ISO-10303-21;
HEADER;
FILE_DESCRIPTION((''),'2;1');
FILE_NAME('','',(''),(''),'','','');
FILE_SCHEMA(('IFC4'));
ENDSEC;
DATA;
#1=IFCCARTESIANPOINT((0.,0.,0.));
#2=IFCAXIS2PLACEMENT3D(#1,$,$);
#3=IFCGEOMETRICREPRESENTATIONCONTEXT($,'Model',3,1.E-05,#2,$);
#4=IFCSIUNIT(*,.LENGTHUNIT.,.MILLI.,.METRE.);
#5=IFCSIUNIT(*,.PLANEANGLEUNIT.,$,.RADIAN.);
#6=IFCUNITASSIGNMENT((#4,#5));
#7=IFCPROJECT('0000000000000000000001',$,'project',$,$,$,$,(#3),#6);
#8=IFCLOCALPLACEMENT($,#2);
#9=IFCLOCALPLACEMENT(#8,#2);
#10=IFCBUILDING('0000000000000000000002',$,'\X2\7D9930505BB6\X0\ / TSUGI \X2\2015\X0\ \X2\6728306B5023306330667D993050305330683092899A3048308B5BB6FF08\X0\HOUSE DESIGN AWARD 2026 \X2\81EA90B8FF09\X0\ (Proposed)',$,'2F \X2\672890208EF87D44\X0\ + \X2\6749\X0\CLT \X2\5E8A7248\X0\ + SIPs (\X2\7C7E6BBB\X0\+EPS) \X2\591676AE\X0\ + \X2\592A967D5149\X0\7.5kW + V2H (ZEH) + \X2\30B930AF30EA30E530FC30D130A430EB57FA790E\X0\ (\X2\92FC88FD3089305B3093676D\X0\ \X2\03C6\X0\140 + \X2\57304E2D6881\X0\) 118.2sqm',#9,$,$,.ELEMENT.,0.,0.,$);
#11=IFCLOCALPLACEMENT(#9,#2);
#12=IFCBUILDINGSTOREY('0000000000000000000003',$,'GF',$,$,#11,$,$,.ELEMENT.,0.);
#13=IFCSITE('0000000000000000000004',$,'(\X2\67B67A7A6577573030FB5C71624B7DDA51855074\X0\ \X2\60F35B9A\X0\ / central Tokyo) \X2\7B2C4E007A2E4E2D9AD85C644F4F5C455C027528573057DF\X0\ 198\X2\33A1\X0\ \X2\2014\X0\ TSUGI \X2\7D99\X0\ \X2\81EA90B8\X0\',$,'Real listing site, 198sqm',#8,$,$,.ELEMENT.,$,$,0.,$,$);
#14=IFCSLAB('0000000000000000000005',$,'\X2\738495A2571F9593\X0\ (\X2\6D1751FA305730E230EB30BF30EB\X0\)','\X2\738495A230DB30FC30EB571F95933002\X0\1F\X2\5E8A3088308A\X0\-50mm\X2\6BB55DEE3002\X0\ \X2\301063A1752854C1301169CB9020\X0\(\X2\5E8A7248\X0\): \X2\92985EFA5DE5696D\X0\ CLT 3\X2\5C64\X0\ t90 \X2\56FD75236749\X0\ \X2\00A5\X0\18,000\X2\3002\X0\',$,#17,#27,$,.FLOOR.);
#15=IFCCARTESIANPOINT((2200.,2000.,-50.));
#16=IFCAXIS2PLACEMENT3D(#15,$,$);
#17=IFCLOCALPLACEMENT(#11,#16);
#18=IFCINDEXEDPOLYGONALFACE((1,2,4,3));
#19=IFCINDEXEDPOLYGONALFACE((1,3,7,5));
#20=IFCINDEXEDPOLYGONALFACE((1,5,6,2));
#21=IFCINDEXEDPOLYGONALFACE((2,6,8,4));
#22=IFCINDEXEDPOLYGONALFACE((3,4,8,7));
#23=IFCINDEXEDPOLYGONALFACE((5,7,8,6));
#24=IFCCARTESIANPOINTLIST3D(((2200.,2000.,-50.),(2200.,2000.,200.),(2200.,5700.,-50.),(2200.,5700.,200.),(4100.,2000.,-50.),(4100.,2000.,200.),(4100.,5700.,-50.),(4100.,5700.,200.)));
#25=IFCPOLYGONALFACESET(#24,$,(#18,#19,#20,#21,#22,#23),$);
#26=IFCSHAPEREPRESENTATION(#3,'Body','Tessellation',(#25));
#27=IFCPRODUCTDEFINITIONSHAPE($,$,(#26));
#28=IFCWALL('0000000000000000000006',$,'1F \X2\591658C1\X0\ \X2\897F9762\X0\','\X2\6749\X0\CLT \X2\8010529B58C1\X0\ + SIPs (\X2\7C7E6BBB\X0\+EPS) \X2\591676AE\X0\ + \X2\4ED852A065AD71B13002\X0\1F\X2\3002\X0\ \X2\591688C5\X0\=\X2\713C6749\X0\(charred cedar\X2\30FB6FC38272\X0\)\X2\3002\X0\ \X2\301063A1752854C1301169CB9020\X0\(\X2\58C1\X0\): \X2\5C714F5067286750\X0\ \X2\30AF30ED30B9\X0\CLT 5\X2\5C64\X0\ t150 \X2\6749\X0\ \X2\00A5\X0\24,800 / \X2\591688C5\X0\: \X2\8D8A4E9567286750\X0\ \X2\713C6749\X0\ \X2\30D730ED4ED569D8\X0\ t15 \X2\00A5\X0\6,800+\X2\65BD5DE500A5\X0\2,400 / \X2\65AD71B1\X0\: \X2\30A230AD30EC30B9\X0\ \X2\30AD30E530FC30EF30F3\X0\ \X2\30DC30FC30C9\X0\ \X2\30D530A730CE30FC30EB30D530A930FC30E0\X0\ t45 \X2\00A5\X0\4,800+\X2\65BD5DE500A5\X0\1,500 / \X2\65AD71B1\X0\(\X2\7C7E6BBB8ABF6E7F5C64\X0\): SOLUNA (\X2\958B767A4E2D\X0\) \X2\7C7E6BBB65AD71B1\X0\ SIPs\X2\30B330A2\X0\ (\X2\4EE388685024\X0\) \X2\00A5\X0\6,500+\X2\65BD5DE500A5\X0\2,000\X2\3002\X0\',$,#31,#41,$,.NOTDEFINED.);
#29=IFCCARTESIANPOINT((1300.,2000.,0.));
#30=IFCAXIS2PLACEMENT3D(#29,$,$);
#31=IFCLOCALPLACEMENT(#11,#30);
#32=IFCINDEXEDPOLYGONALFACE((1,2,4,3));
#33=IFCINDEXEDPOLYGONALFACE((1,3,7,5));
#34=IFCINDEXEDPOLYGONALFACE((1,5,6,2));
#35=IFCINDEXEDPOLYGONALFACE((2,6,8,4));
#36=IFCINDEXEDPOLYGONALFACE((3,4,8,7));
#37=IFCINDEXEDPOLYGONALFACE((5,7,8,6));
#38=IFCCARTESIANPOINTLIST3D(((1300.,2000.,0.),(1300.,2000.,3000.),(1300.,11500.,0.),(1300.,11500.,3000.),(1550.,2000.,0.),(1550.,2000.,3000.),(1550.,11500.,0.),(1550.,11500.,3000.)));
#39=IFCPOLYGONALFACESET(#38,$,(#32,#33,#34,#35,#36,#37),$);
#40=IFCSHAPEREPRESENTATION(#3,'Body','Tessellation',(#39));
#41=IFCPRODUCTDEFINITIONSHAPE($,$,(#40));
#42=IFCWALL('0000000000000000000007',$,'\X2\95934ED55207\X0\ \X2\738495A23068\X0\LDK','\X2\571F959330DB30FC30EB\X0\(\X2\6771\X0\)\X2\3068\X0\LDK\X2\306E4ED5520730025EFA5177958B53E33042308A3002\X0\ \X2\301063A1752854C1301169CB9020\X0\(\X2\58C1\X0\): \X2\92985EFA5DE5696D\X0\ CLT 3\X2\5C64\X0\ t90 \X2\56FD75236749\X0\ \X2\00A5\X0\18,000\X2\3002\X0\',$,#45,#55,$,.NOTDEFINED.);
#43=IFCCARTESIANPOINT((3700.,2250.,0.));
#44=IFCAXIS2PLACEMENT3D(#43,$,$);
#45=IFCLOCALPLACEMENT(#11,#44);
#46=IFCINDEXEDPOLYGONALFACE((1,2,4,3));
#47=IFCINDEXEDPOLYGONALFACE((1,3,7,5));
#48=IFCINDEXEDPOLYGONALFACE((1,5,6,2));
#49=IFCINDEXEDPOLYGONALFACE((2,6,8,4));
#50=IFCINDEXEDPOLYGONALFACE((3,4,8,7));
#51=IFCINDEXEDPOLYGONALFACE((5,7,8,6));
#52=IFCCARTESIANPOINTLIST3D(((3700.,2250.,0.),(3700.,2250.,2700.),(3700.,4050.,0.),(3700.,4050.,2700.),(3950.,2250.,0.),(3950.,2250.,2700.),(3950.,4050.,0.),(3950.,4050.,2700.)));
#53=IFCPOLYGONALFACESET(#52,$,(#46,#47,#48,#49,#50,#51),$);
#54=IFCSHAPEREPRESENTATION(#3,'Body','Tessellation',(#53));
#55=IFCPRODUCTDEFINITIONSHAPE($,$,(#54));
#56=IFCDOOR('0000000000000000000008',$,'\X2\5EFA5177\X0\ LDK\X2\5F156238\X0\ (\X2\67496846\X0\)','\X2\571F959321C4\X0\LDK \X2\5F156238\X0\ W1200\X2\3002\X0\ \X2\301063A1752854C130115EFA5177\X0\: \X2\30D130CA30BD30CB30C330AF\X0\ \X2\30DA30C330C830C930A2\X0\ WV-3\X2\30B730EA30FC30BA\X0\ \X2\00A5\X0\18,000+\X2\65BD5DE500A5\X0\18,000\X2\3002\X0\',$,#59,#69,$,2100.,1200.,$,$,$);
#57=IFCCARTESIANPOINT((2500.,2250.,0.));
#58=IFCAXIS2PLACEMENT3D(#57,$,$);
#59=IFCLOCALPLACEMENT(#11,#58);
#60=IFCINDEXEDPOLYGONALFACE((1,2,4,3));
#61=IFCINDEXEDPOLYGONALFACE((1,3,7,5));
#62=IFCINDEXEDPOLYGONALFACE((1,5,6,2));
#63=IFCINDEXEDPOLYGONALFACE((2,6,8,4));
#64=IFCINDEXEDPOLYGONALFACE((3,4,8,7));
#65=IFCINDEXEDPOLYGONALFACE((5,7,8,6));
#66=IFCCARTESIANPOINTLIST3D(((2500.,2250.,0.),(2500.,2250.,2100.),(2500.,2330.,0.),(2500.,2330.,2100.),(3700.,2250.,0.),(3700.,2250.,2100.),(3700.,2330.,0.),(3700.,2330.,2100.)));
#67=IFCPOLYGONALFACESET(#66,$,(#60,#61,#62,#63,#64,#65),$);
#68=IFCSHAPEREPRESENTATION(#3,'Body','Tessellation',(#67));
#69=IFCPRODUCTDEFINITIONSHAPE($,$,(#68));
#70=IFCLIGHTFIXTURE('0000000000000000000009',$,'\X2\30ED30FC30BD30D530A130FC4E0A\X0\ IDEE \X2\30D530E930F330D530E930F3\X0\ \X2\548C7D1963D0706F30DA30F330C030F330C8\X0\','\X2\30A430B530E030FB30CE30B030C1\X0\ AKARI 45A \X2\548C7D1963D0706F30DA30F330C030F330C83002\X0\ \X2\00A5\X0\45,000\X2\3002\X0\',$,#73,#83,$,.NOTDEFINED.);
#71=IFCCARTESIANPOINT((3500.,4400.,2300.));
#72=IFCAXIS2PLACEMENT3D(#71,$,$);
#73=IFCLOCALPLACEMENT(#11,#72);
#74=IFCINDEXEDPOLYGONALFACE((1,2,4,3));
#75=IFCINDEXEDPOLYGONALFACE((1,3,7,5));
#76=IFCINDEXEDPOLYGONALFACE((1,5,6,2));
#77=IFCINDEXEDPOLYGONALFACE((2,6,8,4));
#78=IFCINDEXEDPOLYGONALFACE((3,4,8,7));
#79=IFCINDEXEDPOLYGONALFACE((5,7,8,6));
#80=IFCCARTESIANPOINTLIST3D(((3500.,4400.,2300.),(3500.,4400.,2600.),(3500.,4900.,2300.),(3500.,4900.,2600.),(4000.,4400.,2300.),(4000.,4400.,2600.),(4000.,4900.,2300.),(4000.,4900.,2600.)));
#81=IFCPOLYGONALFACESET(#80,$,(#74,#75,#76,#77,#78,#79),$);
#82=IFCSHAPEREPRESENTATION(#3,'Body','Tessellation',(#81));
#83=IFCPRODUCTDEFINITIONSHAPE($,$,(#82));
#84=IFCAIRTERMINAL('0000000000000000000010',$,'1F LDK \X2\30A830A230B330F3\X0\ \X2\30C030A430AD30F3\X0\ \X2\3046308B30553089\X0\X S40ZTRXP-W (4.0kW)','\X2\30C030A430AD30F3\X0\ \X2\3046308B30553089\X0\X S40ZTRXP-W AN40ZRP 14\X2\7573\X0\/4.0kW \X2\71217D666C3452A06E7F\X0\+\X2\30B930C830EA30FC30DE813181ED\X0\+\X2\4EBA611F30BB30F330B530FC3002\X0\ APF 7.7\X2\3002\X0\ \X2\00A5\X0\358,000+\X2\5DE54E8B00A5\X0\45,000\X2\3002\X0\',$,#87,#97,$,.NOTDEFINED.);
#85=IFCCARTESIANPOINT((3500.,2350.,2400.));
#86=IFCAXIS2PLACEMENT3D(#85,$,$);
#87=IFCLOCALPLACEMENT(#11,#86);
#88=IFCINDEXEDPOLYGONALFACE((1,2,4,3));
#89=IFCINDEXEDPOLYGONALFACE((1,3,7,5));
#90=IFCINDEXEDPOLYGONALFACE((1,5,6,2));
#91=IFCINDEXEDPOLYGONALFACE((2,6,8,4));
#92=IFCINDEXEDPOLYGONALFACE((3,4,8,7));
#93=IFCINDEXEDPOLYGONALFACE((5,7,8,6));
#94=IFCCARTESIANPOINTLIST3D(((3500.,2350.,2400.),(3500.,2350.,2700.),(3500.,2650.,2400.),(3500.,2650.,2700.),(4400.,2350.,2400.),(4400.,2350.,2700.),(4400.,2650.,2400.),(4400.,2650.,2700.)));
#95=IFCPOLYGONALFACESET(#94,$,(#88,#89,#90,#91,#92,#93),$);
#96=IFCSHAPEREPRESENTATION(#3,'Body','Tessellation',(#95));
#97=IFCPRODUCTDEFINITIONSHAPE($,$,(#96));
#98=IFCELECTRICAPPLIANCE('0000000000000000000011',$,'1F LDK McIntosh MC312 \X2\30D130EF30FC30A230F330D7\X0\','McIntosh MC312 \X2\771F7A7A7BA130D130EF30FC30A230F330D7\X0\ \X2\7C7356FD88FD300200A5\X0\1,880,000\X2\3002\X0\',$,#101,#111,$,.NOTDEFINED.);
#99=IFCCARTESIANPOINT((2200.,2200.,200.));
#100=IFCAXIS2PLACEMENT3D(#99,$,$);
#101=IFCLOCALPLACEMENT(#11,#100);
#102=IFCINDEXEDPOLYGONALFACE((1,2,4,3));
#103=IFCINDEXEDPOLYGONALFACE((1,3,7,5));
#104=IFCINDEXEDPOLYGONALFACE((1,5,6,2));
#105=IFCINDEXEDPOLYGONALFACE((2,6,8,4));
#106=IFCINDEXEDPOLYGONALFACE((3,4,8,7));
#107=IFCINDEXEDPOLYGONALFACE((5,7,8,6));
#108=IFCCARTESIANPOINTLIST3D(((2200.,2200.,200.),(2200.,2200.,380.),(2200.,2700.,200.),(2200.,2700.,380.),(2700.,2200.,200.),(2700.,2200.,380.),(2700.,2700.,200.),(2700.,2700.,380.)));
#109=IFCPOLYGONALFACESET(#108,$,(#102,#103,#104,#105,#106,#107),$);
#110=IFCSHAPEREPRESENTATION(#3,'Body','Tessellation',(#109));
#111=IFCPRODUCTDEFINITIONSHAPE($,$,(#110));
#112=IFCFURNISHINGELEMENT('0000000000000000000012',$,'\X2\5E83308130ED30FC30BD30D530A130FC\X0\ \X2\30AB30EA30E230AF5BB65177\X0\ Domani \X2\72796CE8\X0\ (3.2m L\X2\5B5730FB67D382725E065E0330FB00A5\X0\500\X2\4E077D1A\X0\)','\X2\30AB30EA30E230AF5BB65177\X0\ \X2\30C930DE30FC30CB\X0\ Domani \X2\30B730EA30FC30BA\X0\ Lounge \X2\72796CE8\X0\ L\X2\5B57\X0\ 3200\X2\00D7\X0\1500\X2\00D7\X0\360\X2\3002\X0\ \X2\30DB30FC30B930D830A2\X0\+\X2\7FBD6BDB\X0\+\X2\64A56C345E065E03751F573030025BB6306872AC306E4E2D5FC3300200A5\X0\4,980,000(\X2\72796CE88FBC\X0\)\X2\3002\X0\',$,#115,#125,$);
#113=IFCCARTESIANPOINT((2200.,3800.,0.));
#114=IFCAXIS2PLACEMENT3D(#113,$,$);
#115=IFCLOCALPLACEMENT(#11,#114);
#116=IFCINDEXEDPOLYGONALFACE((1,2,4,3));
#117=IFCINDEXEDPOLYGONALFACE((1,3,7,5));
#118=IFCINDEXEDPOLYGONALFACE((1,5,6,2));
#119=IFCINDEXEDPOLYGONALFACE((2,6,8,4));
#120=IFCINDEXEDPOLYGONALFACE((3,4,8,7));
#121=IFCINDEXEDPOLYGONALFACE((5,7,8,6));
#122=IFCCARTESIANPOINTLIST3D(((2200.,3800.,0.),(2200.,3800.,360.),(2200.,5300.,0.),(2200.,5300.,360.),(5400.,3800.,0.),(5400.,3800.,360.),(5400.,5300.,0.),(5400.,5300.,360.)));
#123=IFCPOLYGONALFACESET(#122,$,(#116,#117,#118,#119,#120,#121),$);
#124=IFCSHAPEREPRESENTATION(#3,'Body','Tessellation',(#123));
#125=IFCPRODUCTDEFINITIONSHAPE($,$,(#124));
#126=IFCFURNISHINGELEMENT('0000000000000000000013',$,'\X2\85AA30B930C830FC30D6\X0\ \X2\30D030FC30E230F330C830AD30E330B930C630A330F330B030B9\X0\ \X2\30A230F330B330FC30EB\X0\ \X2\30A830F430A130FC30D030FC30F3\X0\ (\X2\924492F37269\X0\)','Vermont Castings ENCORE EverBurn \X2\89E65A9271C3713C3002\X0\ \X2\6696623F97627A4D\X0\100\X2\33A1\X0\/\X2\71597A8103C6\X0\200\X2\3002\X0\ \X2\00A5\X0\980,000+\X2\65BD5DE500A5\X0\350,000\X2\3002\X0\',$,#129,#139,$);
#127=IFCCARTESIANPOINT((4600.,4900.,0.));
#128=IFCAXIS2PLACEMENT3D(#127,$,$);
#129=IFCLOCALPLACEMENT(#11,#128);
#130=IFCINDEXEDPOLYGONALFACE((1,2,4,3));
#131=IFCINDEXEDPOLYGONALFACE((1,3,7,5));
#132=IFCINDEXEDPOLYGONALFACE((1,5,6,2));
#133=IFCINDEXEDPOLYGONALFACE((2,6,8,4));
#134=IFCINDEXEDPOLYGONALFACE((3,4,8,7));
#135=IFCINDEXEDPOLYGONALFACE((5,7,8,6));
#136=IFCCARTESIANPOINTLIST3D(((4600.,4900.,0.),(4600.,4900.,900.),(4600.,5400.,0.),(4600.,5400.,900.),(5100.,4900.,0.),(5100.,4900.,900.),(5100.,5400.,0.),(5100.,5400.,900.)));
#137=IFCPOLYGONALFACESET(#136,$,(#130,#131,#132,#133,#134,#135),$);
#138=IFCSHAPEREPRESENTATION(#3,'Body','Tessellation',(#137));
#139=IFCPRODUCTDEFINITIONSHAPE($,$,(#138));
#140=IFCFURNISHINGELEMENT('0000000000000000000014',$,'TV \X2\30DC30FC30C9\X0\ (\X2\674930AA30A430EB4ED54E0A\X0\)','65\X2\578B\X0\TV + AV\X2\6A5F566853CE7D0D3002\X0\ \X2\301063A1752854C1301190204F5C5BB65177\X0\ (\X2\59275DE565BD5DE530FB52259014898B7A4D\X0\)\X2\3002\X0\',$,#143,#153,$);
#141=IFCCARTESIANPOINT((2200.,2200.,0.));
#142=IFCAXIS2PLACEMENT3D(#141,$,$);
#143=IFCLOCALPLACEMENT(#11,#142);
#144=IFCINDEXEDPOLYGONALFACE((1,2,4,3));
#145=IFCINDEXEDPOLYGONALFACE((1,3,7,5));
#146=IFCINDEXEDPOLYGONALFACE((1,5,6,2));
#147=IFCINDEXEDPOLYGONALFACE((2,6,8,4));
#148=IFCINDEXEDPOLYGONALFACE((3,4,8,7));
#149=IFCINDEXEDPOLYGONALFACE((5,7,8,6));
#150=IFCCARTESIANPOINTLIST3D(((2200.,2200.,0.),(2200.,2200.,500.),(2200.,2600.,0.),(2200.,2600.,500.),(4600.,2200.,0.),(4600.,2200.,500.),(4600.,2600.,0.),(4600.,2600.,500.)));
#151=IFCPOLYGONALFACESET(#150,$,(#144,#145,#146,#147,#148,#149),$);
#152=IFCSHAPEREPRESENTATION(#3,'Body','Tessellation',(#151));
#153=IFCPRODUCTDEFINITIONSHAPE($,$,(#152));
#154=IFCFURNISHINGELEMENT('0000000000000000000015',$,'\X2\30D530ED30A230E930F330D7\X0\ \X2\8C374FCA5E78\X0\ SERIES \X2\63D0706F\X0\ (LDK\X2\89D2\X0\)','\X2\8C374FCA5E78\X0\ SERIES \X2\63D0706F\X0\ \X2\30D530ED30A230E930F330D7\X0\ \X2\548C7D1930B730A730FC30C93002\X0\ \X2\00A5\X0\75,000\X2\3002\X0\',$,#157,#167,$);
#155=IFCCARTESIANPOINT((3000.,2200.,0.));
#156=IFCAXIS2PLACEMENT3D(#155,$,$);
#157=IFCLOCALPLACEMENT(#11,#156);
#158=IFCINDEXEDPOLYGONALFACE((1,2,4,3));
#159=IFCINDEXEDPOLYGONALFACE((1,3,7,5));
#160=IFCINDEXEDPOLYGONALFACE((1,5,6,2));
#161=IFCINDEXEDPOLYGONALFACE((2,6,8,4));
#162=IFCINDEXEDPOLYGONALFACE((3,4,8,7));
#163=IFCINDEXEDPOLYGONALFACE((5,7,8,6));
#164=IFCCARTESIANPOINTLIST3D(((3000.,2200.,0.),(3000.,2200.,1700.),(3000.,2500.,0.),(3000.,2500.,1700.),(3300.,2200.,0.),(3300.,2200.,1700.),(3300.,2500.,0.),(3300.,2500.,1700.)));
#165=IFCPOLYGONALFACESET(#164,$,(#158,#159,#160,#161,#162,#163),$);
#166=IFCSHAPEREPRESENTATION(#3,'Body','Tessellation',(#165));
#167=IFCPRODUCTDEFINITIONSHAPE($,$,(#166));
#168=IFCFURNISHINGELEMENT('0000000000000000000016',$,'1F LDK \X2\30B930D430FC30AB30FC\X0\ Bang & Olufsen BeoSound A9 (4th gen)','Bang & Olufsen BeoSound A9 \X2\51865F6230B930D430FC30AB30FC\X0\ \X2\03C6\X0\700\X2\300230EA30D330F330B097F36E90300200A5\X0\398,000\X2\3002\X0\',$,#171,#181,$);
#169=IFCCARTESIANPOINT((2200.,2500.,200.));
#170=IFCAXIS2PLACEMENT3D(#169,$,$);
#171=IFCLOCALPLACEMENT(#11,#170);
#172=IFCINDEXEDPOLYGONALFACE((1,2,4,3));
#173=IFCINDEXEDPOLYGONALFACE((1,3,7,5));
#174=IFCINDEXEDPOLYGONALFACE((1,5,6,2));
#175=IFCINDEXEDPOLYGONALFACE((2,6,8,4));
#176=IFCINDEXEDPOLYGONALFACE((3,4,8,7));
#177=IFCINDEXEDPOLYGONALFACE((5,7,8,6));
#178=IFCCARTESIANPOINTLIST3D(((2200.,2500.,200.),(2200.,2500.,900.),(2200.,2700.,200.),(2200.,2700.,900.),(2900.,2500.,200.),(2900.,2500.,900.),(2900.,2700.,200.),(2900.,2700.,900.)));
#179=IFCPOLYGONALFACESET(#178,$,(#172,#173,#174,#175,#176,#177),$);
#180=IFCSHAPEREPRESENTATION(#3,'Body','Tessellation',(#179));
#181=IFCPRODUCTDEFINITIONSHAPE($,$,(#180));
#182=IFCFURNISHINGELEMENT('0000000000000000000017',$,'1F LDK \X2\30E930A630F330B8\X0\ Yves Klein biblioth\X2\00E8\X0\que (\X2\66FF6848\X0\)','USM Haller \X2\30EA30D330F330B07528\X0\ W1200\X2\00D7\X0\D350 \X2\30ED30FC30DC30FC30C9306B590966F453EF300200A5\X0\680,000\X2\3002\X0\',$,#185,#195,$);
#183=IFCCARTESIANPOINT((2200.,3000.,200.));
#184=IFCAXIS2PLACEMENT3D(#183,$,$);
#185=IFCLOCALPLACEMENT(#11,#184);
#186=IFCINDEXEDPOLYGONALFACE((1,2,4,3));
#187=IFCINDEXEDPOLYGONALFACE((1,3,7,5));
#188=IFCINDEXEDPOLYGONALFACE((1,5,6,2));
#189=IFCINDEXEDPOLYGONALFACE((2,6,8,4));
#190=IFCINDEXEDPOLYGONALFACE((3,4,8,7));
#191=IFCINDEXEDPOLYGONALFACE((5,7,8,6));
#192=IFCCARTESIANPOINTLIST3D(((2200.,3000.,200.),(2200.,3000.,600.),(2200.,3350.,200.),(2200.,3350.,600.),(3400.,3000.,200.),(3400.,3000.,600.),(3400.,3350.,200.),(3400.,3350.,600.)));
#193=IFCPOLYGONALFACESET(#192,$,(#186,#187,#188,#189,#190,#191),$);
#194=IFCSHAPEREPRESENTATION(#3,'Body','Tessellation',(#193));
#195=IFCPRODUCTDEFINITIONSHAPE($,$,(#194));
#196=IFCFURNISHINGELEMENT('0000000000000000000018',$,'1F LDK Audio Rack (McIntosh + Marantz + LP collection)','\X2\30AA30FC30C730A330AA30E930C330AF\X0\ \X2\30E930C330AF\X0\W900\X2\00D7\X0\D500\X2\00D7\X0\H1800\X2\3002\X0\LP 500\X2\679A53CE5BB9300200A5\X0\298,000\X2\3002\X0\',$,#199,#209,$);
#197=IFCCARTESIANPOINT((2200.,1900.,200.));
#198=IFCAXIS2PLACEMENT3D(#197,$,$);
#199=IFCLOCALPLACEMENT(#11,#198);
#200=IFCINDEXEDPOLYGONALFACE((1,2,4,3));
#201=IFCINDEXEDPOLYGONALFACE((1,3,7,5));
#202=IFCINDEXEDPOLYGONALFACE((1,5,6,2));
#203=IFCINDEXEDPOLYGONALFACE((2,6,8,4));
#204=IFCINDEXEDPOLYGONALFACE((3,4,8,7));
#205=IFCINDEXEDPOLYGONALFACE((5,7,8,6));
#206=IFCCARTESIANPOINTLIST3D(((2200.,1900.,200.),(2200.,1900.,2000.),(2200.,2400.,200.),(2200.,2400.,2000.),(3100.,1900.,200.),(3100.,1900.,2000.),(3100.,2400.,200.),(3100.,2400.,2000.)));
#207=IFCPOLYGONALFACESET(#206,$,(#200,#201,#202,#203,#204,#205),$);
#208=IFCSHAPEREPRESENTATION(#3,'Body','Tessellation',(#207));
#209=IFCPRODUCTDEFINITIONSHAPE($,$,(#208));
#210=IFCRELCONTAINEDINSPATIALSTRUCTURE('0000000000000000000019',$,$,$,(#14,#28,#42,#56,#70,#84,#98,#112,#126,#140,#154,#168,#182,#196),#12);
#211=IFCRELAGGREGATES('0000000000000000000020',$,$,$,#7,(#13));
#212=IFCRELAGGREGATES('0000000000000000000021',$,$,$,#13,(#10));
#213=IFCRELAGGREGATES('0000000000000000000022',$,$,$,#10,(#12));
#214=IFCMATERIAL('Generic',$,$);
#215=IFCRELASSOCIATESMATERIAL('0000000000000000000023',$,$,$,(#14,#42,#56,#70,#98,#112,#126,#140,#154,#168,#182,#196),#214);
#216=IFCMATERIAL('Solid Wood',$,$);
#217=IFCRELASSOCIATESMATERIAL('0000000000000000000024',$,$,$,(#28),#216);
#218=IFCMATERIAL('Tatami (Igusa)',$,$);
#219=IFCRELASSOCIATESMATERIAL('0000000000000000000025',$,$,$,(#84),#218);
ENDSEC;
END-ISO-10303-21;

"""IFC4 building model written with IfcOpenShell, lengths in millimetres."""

from ifc_helpers import new_model, si_unit, frame, frame_2d, origin, place, context, project, spatial, rectangle, extrude, material, element, save


model = new_model("IFC4")

# Units and contexts
model_context = context("Model", 3, precision=1e-05, world=origin())
ifc_project = project(units=[si_unit("LENGTHUNIT", "METRE", prefix="MILLI"), si_unit("PLANEANGLEUNIT", "RADIAN")], contexts=[model_context])

# Site, building, storey
site_placement = place(None, origin())
site = spatial("IfcSite", under=ifc_project, at=site_placement, Name="(架空敷地・山手線内側 想定 / central Tokyo) 第一種中高層住居専用地域 198㎡ — TSUGI 継 自邸", ObjectType="Real listing site, 198sqm", CompositionType="ELEMENT", RefElevation=0.0)
building_placement = place(site_placement, origin())
building = spatial("IfcBuilding", under=site, at=building_placement, Name="継ぐ家 / TSUGI ― 木に倣って継ぐことを覚える家（HOUSE DESIGN AWARD 2026 自邸） (Proposed)", ObjectType="2F 木造軸組 + 杉CLT 床版 + SIPs (籾殻+EPS) 外皮 + 太陽光7.5kW + V2H (ZEH) + スクリューパイル基礎 (鋼製らせん杭 φ140 + 地中梁) 118.2sqm", CompositionType="ELEMENT", ElevationOfRefHeight=0.0, ElevationOfTerrain=0.0)
storey_placement = place(building_placement, origin())
storey = spatial("IfcBuildingStorey", under=building, at=storey_placement, Name="GF", CompositionType="ELEMENT", Elevation=0.0)

# Shared definitions
ifc_material_1 = material(Name="Generic")

# Slab
slab_1_placement = place(storey_placement, frame((2200.0, 2000.0, -50.0)))
element("IfcSlab", 1, at=slab_1_placement, inside=storey, material=ifc_material_1, Name="玄関土間 (洗出しモルタル)", Description="玄関ホール土間。1F床より-50mm段差。 【採用品】構造(床版): 銘建工業 CLT 3層 t90 国産杉 ¥18,000。", PredefinedType="FLOOR", context=model_context, shape_type="SweptSolid", body=[
    extrude(rectangle(XDim=1900.0, YDim=3700.0, at=frame_2d((950.0, 1850.0))), frame((2200.0, 2000.0, -50.0)), (0.0, 0.0, 1.0), 250.0),
])

# Shared definitions
ifc_material_2 = material(Name="Solid Wood")

# Walls
wall_1_placement = place(storey_placement, frame((1300.0, 2000.0, 0.0)))
element("IfcWall", 2, at=wall_1_placement, inside=storey, material=ifc_material_2, Name="1F 外壁 西面", Description="杉CLT 耐力壁 + SIPs (籾殻+EPS) 外皮 + 付加断熱。1F。 外装=焼杉(charred cedar・濃色)。 【採用品】構造(壁): 山佐木材 クロスCLT 5層 t150 杉 ¥24,800 / 外装: 越井木材 焼杉 プロ仕様 t15 ¥6,800+施工¥2,400 / 断熱: アキレス キューワン ボード フェノールフォーム t45 ¥4,800+施工¥1,500 / 断熱(籾殻調湿層): SOLUNA (開発中) 籾殻断熱 SIPsコア (代表値) ¥6,500+施工¥2,000。", PredefinedType="NOTDEFINED", context=model_context, shape_type="SweptSolid", body=[
    extrude(rectangle(XDim=250.0, YDim=9500.0, at=frame_2d((125.0, 4750.0))), frame((1300.0, 2000.0, 0.0)), (0.0, 0.0, 1.0), 3000.0),
])
wall_2_placement = place(storey_placement, frame((3700.0, 2250.0, 0.0)))
element("IfcWall", 3, at=wall_2_placement, inside=storey, material=ifc_material_1, Name="間仕切 玄関とLDK", Description="土間ホール(東)とLDKの仕切。建具開口あり。 【採用品】構造(壁): 銘建工業 CLT 3層 t90 国産杉 ¥18,000。", PredefinedType="NOTDEFINED", context=model_context, shape_type="SweptSolid", body=[
    extrude(rectangle(XDim=250.0, YDim=1800.0, at=frame_2d((125.0, 900.0))), frame((3700.0, 2250.0, 0.0)), (0.0, 0.0, 1.0), 2700.0),
])

# Door
door_placement = place(storey_placement, frame((2500.0, 2250.0, 0.0)))
element("IfcDoor", 4, at=door_placement, inside=storey, material=ifc_material_1, Name="建具 LDK引戸 (杉框)", Description="土間⇄LDK 引戸 W1200。 【採用品】建具: パナソニック ペットドア WV-3シリーズ ¥18,000+施工¥18,000。", OverallHeight=2100.0, OverallWidth=1200.0, context=model_context, shape_type="SweptSolid", body=[
    extrude(rectangle(XDim=1200.0, YDim=80.0, at=frame_2d((600.0, 40.0))), frame((2500.0, 2250.0, 0.0)), (0.0, 0.0, 1.0), 2100.0),
])

# Light fixture
light_fixture_placement = place(storey_placement, frame((3500.0, 4400.0, 2300.0)))
element("IfcLightFixture", 5, at=light_fixture_placement, inside=storey, material=ifc_material_1, Name="ローソファー上 IDEE フランフラン 和紙提灯ペンダント", Description="イサム・ノグチ AKARI 45A 和紙提灯ペンダント。 ¥45,000。", PredefinedType="NOTDEFINED", context=model_context, shape_type="SweptSolid", body=[
    extrude(rectangle(XDim=500.0, YDim=500.0, at=frame_2d((250.0, 250.0))), frame((3500.0, 4400.0, 2300.0)), (0.0, 0.0, 1.0), 300.0),
])

# Air terminal
ifc_material_3 = material(Name="Tatami (Igusa)")
air_terminal_placement = place(storey_placement, frame((3500.0, 2350.0, 2400.0)))
element("IfcAirTerminal", 6, at=air_terminal_placement, inside=storey, material=ifc_material_3, Name="1F LDK エアコン ダイキン うるさらX S40ZTRXP-W (4.0kW)", Description="ダイキン うるさらX S40ZTRXP-W AN40ZRP 14畳/4.0kW 無給水加湿+ストリーマ脱臭+人感センサー。 APF 7.7。 ¥358,000+工事¥45,000。", PredefinedType="NOTDEFINED", context=model_context, shape_type="SweptSolid", body=[
    extrude(rectangle(XDim=900.0, YDim=300.0, at=frame_2d((450.0, 150.0))), frame((3500.0, 2350.0, 2400.0)), (0.0, 0.0, 1.0), 300.0),
])

# Electric appliance
electric_appliance_placement = place(storey_placement, frame((2200.0, 2200.0, 200.0)))
element("IfcElectricAppliance", 7, at=electric_appliance_placement, inside=storey, material=ifc_material_1, Name="1F LDK McIntosh MC312 パワーアンプ", Description="McIntosh MC312 真空管パワーアンプ 米国製。¥1,880,000。", PredefinedType="NOTDEFINED", context=model_context, shape_type="SweptSolid", body=[
    extrude(rectangle(XDim=500.0, YDim=500.0, at=frame_2d((250.0, 250.0))), frame((2200.0, 2200.0, 200.0)), (0.0, 0.0, 1.0), 180.0),
])

# Furnishing elements
furnishing_1_placement = place(storey_placement, frame((2200.0, 3800.0, 0.0)))
element("IfcFurnishingElement", 8, at=furnishing_1_placement, inside=storey, material=ifc_material_1, Name="広めローソファー カリモク家具 Domani 特注 (3.2m L字・染色帆布・¥500万級)", Description="カリモク家具 ドマーニ Domani シリーズ Lounge 特注 L字 3200×1500×360。 ホースヘア+羽毛+撥水帆布生地。家と犬の中心。¥4,980,000(特注込)。", context=model_context, shape_type="SweptSolid", body=[
    extrude(rectangle(XDim=3200.0, YDim=1500.0, at=frame_2d((1600.0, 750.0))), frame((2200.0, 3800.0, 0.0)), (0.0, 0.0, 1.0), 360.0),
])
furnishing_2_placement = place(storey_placement, frame((4600.0, 4900.0, 0.0)))
element("IfcFurnishingElement", 9, at=furnishing_2_placement, inside=storey, material=ifc_material_1, Name="薪ストーブ バーモントキャスティングス アンコール エヴァーバーン (鉄鋳物)", Description="Vermont Castings ENCORE EverBurn 触媒燃焼。 暖房面積100㎡/煙突φ200。 ¥980,000+施工¥350,000。", context=model_context, shape_type="SweptSolid", body=[
    extrude(rectangle(XDim=500.0, YDim=500.0, at=frame_2d((250.0, 250.0))), frame((4600.0, 4900.0, 0.0)), (0.0, 0.0, 1.0), 900.0),
])
furnishing_3_placement = place(storey_placement, frame((2200.0, 2200.0, 0.0)))
element("IfcFurnishingElement", 10, at=furnishing_3_placement, inside=storey, material=ifc_material_1, Name="TV ボード (杉オイル仕上)", Description="65型TV + AV機器収納。 【採用品】造作家具 (大工施工・別途見積)。", context=model_context, shape_type="SweptSolid", body=[
    extrude(rectangle(XDim=2400.0, YDim=400.0, at=frame_2d((1200.0, 200.0))), frame((2200.0, 2200.0, 0.0)), (0.0, 0.0, 1.0), 500.0),
])
furnishing_4_placement = place(storey_placement, frame((3000.0, 2200.0, 0.0)))
element("IfcFurnishingElement", 11, at=furnishing_4_placement, inside=storey, material=ifc_material_1, Name="フロアランプ 谷俊幸 SERIES 提灯 (LDK角)", Description="谷俊幸 SERIES 提灯 フロアランプ 和紙シェード。 ¥75,000。", context=model_context, shape_type="SweptSolid", body=[
    extrude(rectangle(XDim=300.0, YDim=300.0, at=frame_2d((150.0, 150.0))), frame((3000.0, 2200.0, 0.0)), (0.0, 0.0, 1.0), 1700.0),
])
furnishing_5_placement = place(storey_placement, frame((2200.0, 2500.0, 200.0)))
element("IfcFurnishingElement", 12, at=furnishing_5_placement, inside=storey, material=ifc_material_1, Name="1F LDK スピーカー Bang & Olufsen BeoSound A9 (4th gen)", Description="Bang & Olufsen BeoSound A9 円形スピーカー φ700。リビング音源。¥398,000。", context=model_context, shape_type="SweptSolid", body=[
    extrude(rectangle(XDim=700.0, YDim=200.0, at=frame_2d((350.0, 100.0))), frame((2200.0, 2500.0, 200.0)), (0.0, 0.0, 1.0), 700.0),
])
furnishing_6_placement = place(storey_placement, frame((2200.0, 3000.0, 200.0)))
element("IfcFurnishingElement", 13, at=furnishing_6_placement, inside=storey, material=ifc_material_1, Name="1F LDK ラウンジ Yves Klein bibliothèque (替案)", Description="USM Haller リビング用 W1200×D350 ローボードに変更可。¥680,000。", context=model_context, shape_type="SweptSolid", body=[
    extrude(rectangle(XDim=1200.0, YDim=350.0, at=frame_2d((600.0, 175.0))), frame((2200.0, 3000.0, 200.0)), (0.0, 0.0, 1.0), 400.0),
])
furnishing_7_placement = place(storey_placement, frame((2200.0, 1900.0, 200.0)))
element("IfcFurnishingElement", 14, at=furnishing_7_placement, inside=storey, material=ifc_material_1, Name="1F LDK Audio Rack (McIntosh + Marantz + LP collection)", Description="オーディオラック ラックW900×D500×H1800。LP 500枚収容。¥298,000。", context=model_context, shape_type="SweptSolid", body=[
    extrude(rectangle(XDim=900.0, YDim=500.0, at=frame_2d((450.0, 250.0))), frame((2200.0, 1900.0, 200.0)), (0.0, 0.0, 1.0), 1800.0),
])

save(model, "model.ifc")
